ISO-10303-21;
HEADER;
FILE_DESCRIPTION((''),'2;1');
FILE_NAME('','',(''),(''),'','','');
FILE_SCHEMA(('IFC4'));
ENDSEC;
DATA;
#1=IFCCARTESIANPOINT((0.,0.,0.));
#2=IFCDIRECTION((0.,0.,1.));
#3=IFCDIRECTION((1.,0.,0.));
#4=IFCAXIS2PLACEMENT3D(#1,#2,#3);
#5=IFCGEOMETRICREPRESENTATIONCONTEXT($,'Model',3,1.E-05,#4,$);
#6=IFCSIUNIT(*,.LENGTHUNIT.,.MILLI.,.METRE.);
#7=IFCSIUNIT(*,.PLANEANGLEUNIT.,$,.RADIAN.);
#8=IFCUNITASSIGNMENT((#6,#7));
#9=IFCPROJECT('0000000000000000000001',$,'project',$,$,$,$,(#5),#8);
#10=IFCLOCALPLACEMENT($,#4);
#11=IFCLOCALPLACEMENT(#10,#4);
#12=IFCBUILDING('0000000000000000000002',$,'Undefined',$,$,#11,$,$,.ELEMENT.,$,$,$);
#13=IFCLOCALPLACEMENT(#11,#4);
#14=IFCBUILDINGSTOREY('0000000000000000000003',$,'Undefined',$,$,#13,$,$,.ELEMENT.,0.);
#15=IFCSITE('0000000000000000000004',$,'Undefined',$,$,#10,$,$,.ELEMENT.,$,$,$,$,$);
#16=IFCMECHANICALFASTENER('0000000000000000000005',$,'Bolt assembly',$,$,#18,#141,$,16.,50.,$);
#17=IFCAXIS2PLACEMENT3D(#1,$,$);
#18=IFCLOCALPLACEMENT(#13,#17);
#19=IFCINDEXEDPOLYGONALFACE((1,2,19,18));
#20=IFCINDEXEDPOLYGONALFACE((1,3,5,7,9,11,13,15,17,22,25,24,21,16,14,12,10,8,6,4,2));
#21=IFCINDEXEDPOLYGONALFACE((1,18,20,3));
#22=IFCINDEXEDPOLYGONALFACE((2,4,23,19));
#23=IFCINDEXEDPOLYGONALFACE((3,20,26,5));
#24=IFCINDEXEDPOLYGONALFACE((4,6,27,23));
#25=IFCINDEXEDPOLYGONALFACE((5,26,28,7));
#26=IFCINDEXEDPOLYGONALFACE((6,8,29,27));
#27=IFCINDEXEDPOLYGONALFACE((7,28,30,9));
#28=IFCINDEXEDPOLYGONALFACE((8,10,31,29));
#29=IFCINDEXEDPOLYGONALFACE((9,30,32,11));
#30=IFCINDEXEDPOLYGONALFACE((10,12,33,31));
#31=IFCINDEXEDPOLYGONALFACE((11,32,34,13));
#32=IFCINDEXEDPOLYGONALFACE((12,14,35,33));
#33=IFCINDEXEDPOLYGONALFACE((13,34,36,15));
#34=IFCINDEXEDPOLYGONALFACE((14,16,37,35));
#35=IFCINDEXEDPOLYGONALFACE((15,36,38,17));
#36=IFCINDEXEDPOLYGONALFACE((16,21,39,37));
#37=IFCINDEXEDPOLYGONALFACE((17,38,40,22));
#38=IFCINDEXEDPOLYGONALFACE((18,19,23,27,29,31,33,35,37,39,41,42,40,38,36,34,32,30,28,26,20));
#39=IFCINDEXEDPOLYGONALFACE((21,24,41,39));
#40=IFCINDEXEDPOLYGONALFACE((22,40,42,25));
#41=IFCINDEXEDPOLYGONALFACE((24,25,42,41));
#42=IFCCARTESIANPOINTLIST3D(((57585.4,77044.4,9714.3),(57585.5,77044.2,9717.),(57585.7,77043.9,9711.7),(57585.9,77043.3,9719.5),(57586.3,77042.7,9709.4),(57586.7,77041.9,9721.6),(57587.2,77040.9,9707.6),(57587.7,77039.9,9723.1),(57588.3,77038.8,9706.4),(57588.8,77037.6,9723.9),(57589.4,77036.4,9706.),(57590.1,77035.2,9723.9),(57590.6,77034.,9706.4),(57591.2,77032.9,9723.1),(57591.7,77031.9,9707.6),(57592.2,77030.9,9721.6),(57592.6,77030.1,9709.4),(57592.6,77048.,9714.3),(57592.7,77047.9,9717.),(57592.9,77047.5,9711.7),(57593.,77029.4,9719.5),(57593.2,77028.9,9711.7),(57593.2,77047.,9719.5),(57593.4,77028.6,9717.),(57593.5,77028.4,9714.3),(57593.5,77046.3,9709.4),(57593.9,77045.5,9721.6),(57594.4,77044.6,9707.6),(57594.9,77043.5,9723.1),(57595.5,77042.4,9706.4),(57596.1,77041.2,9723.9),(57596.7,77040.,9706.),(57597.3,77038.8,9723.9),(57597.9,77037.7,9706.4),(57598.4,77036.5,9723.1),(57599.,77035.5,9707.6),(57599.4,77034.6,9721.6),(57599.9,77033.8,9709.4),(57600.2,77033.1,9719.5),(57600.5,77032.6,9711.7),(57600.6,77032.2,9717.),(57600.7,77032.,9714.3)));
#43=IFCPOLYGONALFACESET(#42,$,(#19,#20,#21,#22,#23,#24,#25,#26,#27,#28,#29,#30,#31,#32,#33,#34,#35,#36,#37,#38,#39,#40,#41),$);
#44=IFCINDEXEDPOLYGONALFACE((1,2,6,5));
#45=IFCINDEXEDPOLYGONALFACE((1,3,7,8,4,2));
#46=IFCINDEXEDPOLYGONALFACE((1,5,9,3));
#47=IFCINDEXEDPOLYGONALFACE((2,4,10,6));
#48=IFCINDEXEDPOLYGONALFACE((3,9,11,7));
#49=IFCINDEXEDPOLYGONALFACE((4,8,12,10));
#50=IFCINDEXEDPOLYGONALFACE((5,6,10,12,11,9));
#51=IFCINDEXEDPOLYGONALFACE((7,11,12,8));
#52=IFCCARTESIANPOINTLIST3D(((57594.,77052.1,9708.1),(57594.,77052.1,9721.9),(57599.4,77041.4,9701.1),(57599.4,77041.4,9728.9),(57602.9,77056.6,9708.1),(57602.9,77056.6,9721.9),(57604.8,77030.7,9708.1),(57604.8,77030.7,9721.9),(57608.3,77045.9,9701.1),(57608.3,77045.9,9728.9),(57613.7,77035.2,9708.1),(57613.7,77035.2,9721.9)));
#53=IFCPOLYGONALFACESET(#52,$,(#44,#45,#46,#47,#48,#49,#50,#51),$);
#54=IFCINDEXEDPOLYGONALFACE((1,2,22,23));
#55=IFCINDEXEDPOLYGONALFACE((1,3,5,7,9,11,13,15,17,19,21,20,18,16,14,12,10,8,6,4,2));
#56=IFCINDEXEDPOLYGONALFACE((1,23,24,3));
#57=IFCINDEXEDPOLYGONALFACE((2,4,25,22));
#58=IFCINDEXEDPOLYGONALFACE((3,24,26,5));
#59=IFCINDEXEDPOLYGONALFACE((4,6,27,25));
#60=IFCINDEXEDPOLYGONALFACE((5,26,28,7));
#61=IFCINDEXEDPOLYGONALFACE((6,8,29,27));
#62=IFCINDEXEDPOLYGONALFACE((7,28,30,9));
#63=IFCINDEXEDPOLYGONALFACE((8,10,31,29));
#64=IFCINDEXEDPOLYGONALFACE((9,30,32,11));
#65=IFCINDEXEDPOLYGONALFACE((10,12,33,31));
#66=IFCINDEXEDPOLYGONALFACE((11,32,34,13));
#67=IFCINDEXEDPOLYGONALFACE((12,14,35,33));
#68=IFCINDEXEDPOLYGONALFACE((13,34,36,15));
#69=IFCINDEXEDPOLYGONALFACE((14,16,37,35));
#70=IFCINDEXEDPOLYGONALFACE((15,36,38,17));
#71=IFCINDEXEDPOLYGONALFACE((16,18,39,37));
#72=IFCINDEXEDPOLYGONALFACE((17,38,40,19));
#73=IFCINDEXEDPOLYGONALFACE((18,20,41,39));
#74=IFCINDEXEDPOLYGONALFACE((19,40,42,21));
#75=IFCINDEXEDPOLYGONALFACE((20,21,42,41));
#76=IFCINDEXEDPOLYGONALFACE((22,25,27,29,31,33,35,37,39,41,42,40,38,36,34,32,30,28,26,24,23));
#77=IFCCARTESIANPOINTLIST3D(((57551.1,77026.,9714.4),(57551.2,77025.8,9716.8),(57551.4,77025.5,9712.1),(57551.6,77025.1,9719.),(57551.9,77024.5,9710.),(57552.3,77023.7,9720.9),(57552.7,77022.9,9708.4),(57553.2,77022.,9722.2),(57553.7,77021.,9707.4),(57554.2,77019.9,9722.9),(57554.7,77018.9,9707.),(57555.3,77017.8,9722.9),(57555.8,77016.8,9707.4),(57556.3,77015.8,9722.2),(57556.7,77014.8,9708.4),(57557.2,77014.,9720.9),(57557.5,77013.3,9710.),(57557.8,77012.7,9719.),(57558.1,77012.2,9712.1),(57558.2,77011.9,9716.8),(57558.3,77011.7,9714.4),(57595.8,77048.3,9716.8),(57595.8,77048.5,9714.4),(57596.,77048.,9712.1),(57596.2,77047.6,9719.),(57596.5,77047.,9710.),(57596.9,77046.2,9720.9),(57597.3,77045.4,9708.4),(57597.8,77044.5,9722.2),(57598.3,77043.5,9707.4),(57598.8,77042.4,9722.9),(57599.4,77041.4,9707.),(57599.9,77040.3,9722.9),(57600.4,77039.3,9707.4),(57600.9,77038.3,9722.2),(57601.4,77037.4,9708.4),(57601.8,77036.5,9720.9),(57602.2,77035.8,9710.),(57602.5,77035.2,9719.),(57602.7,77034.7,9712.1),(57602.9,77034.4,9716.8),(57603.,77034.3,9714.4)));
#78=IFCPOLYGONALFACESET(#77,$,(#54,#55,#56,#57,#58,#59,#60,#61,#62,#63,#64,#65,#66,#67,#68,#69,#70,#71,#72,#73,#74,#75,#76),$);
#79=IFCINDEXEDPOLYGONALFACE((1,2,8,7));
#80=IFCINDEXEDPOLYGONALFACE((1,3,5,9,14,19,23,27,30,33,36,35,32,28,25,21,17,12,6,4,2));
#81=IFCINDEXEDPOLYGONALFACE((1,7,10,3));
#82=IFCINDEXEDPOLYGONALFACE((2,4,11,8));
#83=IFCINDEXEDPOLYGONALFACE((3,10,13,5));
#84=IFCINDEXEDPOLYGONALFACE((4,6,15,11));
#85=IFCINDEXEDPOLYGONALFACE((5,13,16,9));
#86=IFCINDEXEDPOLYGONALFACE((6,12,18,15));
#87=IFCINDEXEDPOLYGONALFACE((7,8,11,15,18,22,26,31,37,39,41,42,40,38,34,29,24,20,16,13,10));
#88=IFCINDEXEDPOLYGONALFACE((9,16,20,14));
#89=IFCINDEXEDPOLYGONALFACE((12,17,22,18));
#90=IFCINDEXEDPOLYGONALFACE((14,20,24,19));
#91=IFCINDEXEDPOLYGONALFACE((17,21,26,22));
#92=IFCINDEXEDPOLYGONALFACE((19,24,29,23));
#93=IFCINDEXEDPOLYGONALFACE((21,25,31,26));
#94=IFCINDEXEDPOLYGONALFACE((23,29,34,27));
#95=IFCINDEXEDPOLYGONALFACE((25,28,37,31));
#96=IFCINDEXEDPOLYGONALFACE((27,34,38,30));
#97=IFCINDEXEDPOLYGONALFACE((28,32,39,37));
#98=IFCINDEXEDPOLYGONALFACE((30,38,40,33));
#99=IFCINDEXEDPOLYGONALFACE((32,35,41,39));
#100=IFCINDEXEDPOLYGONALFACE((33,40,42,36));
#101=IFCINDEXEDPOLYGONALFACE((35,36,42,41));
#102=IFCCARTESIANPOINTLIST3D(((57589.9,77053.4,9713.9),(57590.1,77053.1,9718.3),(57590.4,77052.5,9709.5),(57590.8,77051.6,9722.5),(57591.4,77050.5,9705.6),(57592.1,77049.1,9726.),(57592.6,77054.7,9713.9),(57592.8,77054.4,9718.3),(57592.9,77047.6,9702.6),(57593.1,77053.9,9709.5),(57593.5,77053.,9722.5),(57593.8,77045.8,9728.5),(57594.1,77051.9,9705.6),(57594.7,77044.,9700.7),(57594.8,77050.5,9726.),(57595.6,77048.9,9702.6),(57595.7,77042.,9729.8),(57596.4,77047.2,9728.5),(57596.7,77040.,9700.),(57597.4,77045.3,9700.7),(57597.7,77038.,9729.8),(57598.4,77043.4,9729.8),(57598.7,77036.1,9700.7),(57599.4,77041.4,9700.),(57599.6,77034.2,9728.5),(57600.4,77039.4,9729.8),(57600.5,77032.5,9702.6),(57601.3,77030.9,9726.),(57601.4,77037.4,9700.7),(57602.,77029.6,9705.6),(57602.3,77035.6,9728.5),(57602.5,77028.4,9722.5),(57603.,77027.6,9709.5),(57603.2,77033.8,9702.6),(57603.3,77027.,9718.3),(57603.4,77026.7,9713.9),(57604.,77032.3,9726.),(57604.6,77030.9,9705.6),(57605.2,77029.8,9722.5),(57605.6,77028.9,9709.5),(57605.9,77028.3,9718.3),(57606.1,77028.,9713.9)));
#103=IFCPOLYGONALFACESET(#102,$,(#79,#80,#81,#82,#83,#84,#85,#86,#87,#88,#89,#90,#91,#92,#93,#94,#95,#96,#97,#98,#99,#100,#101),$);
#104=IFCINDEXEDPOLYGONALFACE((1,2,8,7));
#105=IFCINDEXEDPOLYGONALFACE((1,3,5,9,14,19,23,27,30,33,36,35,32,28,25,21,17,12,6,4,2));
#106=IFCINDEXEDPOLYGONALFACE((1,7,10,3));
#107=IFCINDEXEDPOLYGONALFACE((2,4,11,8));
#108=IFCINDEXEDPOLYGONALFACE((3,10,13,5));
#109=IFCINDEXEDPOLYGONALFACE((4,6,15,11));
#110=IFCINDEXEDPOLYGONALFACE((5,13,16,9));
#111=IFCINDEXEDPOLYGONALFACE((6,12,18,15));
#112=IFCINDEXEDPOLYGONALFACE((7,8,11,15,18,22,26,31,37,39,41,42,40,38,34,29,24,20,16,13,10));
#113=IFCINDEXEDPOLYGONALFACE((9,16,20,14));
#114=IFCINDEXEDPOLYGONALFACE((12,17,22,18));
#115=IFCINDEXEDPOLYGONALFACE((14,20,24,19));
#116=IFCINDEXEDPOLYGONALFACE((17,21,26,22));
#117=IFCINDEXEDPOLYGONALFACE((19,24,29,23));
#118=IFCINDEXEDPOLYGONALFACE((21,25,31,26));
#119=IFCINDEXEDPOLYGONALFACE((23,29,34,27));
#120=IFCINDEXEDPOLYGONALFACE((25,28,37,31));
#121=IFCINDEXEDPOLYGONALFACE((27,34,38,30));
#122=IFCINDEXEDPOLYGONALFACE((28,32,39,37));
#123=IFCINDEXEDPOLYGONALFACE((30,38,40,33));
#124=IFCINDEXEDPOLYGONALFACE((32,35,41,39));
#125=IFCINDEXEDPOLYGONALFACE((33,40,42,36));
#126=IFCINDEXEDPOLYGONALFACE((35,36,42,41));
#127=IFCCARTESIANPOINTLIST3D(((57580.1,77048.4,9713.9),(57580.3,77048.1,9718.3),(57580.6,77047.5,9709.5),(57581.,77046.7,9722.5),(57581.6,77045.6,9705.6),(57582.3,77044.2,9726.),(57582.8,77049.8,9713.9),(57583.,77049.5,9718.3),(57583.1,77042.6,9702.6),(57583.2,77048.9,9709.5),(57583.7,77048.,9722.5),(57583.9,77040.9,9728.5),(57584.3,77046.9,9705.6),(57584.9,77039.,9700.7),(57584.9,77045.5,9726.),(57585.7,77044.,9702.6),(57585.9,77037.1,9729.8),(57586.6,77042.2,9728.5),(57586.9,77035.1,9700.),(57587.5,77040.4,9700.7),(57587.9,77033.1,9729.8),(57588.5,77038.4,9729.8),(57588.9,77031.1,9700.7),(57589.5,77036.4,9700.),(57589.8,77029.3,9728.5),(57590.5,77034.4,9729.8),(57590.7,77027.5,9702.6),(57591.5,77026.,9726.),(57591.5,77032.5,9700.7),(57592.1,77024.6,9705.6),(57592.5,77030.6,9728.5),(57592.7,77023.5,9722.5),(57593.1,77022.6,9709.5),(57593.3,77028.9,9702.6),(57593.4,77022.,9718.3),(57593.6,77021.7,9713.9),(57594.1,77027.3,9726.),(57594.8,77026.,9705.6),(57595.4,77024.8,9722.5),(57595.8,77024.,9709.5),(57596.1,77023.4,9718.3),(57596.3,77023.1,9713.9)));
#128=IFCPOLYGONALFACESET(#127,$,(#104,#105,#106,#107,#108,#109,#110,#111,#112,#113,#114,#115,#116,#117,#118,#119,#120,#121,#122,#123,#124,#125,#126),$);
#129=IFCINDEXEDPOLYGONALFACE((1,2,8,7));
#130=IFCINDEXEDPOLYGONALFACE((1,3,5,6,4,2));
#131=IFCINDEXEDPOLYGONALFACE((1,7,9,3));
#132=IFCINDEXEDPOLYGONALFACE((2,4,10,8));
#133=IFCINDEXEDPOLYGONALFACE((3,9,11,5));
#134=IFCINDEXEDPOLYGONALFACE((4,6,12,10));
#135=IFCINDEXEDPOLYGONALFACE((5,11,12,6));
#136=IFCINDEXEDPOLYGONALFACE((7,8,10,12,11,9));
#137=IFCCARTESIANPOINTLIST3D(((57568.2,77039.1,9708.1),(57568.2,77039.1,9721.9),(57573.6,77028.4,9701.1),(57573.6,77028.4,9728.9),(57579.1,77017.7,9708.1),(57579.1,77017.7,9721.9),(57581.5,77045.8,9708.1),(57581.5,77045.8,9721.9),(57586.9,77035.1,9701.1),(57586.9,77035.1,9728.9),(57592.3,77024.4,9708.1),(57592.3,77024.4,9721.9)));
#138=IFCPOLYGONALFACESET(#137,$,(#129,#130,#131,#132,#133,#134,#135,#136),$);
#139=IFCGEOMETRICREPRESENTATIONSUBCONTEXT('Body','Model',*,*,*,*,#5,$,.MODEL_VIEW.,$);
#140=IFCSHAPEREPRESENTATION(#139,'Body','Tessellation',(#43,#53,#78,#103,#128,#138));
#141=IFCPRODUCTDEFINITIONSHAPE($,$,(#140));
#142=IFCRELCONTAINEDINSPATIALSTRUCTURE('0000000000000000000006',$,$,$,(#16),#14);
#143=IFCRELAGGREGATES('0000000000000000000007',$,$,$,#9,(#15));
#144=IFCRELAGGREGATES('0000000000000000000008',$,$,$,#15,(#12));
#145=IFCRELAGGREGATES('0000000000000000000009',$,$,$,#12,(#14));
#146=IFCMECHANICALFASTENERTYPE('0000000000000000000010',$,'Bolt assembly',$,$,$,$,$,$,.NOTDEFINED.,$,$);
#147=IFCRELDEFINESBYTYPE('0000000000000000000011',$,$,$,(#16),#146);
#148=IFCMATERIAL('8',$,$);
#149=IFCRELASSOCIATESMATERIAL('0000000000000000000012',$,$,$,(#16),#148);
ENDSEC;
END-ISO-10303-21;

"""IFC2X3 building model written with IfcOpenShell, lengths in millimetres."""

from ifc_helpers import new_model, si_unit, frame, origin_with_axes, origin_2d_with_axis, place, context, subcontext, project, spatial, polyline, circle, outline, extrude, source, transform, mapped, material, type_object, element, save


model = new_model("IFC2X3")

# Units and contexts
model_context = context("Model", 3, precision=1e-05, world=origin_with_axes())
body_context = subcontext(model_context, "Body", "Model", "MODEL_VIEW")
ifc_project = project(units=[si_unit("LENGTHUNIT", "METRE", prefix="MILLI"), si_unit("PLANEANGLEUNIT", "RADIAN")], contexts=[model_context])

# Site, building, storey
site_placement = place(None, origin_with_axes())
site = spatial("IfcSite", under=ifc_project, at=site_placement, Name="Undefined", CompositionType="ELEMENT")
building_placement = place(site_placement, origin_with_axes())
building = spatial("IfcBuilding", under=site, at=building_placement, Name="Undefined", CompositionType="ELEMENT")
storey_placement = place(building_placement, origin_with_axes())
storey = spatial("IfcBuildingStorey", under=building, at=storey_placement, Name="Undefined", CompositionType="ELEMENT", Elevation=0.0)

# Mechanical fastener
ifc_material_1 = material(Name="8")
mechanical_fastener_type = type_object("IfcMechanicalFastenerType", Name="Bolt assembly")
shared_shape_1 = source(origin_with_axes(), body_context, "Body", "SweptSolid", [
    extrude(circle(Radius=9.0, at=origin_2d_with_axis()), frame((0.0, 0.0, 0.0), z_axis=(0.0, 1.0, 0.0), x_axis=(1.0, 0.0, 0.0)), (0.0, 0.0, 1.0), 8.1),
    extrude(outline(polyline([(13.9, 0.0), (6.9, 12.0), (-6.9, 12.0), (-13.9, 0.0), (-6.9, -12.0), (6.9, -12.0), (13.9, 0.0)])), frame((0.0, -13.0, 0.0), z_axis=(0.0, 1.0, 0.0), x_axis=(1.0, 0.0, 0.0)), (0.0, 0.0, 1.0), 10.0),
    extrude(circle(Radius=8.0, at=origin_2d_with_axis()), frame((0.0, -3.0, 0.0), z_axis=(0.0, 1.0, 0.0), x_axis=(1.0, 0.0, 0.0)), (0.0, 0.0, 1.0), 50.0),
    extrude(circle(Radius=15.0, at=origin_2d_with_axis()), frame((0.0, -3.0, 0.0), z_axis=(0.0, 1.0, 0.0), x_axis=(1.0, 0.0, 0.0)), (0.0, 0.0, 1.0), 3.0),
    extrude(circle(Radius=15.0, at=origin_2d_with_axis()), frame((0.0, 8.0, 0.0), z_axis=(0.0, 1.0, 0.0), x_axis=(1.0, 0.0, 0.0)), (0.0, 0.0, 1.0), 3.0),
    extrude(outline(polyline([(13.9, 0.0), (6.9, 12.0), (-6.9, 12.0), (-13.9, 0.0), (-6.9, -12.0), (6.9, -12.0), (13.9, 0.0)])), frame((0.0, 11.0, 0.0), z_axis=(0.0, 1.0, 0.0), x_axis=(1.0, 0.0, 0.0)), (0.0, 0.0, 1.0), 14.8),
])
mechanical_fastener_1_placement = place(storey_placement, frame((57596.7, 77040.0, 9715.0), z_axis=(-0.45041, 0.892822, 0.000127), x_axis=(-0.000057, 0.000114, -1.0)))
element("IfcMechanicalFastener", 1, at=mechanical_fastener_1_placement, inside=storey, type_object=mechanical_fastener_type, material=ifc_material_1, Name="Bolt assembly", NominalDiameter=16.0, NominalLength=50.0, context=body_context, shape_type="MappedRepresentation", body=[
    mapped(shared_shape_1, transform((0.0, 0.0, 0.0))),
])

save(model, "model.ifc")
